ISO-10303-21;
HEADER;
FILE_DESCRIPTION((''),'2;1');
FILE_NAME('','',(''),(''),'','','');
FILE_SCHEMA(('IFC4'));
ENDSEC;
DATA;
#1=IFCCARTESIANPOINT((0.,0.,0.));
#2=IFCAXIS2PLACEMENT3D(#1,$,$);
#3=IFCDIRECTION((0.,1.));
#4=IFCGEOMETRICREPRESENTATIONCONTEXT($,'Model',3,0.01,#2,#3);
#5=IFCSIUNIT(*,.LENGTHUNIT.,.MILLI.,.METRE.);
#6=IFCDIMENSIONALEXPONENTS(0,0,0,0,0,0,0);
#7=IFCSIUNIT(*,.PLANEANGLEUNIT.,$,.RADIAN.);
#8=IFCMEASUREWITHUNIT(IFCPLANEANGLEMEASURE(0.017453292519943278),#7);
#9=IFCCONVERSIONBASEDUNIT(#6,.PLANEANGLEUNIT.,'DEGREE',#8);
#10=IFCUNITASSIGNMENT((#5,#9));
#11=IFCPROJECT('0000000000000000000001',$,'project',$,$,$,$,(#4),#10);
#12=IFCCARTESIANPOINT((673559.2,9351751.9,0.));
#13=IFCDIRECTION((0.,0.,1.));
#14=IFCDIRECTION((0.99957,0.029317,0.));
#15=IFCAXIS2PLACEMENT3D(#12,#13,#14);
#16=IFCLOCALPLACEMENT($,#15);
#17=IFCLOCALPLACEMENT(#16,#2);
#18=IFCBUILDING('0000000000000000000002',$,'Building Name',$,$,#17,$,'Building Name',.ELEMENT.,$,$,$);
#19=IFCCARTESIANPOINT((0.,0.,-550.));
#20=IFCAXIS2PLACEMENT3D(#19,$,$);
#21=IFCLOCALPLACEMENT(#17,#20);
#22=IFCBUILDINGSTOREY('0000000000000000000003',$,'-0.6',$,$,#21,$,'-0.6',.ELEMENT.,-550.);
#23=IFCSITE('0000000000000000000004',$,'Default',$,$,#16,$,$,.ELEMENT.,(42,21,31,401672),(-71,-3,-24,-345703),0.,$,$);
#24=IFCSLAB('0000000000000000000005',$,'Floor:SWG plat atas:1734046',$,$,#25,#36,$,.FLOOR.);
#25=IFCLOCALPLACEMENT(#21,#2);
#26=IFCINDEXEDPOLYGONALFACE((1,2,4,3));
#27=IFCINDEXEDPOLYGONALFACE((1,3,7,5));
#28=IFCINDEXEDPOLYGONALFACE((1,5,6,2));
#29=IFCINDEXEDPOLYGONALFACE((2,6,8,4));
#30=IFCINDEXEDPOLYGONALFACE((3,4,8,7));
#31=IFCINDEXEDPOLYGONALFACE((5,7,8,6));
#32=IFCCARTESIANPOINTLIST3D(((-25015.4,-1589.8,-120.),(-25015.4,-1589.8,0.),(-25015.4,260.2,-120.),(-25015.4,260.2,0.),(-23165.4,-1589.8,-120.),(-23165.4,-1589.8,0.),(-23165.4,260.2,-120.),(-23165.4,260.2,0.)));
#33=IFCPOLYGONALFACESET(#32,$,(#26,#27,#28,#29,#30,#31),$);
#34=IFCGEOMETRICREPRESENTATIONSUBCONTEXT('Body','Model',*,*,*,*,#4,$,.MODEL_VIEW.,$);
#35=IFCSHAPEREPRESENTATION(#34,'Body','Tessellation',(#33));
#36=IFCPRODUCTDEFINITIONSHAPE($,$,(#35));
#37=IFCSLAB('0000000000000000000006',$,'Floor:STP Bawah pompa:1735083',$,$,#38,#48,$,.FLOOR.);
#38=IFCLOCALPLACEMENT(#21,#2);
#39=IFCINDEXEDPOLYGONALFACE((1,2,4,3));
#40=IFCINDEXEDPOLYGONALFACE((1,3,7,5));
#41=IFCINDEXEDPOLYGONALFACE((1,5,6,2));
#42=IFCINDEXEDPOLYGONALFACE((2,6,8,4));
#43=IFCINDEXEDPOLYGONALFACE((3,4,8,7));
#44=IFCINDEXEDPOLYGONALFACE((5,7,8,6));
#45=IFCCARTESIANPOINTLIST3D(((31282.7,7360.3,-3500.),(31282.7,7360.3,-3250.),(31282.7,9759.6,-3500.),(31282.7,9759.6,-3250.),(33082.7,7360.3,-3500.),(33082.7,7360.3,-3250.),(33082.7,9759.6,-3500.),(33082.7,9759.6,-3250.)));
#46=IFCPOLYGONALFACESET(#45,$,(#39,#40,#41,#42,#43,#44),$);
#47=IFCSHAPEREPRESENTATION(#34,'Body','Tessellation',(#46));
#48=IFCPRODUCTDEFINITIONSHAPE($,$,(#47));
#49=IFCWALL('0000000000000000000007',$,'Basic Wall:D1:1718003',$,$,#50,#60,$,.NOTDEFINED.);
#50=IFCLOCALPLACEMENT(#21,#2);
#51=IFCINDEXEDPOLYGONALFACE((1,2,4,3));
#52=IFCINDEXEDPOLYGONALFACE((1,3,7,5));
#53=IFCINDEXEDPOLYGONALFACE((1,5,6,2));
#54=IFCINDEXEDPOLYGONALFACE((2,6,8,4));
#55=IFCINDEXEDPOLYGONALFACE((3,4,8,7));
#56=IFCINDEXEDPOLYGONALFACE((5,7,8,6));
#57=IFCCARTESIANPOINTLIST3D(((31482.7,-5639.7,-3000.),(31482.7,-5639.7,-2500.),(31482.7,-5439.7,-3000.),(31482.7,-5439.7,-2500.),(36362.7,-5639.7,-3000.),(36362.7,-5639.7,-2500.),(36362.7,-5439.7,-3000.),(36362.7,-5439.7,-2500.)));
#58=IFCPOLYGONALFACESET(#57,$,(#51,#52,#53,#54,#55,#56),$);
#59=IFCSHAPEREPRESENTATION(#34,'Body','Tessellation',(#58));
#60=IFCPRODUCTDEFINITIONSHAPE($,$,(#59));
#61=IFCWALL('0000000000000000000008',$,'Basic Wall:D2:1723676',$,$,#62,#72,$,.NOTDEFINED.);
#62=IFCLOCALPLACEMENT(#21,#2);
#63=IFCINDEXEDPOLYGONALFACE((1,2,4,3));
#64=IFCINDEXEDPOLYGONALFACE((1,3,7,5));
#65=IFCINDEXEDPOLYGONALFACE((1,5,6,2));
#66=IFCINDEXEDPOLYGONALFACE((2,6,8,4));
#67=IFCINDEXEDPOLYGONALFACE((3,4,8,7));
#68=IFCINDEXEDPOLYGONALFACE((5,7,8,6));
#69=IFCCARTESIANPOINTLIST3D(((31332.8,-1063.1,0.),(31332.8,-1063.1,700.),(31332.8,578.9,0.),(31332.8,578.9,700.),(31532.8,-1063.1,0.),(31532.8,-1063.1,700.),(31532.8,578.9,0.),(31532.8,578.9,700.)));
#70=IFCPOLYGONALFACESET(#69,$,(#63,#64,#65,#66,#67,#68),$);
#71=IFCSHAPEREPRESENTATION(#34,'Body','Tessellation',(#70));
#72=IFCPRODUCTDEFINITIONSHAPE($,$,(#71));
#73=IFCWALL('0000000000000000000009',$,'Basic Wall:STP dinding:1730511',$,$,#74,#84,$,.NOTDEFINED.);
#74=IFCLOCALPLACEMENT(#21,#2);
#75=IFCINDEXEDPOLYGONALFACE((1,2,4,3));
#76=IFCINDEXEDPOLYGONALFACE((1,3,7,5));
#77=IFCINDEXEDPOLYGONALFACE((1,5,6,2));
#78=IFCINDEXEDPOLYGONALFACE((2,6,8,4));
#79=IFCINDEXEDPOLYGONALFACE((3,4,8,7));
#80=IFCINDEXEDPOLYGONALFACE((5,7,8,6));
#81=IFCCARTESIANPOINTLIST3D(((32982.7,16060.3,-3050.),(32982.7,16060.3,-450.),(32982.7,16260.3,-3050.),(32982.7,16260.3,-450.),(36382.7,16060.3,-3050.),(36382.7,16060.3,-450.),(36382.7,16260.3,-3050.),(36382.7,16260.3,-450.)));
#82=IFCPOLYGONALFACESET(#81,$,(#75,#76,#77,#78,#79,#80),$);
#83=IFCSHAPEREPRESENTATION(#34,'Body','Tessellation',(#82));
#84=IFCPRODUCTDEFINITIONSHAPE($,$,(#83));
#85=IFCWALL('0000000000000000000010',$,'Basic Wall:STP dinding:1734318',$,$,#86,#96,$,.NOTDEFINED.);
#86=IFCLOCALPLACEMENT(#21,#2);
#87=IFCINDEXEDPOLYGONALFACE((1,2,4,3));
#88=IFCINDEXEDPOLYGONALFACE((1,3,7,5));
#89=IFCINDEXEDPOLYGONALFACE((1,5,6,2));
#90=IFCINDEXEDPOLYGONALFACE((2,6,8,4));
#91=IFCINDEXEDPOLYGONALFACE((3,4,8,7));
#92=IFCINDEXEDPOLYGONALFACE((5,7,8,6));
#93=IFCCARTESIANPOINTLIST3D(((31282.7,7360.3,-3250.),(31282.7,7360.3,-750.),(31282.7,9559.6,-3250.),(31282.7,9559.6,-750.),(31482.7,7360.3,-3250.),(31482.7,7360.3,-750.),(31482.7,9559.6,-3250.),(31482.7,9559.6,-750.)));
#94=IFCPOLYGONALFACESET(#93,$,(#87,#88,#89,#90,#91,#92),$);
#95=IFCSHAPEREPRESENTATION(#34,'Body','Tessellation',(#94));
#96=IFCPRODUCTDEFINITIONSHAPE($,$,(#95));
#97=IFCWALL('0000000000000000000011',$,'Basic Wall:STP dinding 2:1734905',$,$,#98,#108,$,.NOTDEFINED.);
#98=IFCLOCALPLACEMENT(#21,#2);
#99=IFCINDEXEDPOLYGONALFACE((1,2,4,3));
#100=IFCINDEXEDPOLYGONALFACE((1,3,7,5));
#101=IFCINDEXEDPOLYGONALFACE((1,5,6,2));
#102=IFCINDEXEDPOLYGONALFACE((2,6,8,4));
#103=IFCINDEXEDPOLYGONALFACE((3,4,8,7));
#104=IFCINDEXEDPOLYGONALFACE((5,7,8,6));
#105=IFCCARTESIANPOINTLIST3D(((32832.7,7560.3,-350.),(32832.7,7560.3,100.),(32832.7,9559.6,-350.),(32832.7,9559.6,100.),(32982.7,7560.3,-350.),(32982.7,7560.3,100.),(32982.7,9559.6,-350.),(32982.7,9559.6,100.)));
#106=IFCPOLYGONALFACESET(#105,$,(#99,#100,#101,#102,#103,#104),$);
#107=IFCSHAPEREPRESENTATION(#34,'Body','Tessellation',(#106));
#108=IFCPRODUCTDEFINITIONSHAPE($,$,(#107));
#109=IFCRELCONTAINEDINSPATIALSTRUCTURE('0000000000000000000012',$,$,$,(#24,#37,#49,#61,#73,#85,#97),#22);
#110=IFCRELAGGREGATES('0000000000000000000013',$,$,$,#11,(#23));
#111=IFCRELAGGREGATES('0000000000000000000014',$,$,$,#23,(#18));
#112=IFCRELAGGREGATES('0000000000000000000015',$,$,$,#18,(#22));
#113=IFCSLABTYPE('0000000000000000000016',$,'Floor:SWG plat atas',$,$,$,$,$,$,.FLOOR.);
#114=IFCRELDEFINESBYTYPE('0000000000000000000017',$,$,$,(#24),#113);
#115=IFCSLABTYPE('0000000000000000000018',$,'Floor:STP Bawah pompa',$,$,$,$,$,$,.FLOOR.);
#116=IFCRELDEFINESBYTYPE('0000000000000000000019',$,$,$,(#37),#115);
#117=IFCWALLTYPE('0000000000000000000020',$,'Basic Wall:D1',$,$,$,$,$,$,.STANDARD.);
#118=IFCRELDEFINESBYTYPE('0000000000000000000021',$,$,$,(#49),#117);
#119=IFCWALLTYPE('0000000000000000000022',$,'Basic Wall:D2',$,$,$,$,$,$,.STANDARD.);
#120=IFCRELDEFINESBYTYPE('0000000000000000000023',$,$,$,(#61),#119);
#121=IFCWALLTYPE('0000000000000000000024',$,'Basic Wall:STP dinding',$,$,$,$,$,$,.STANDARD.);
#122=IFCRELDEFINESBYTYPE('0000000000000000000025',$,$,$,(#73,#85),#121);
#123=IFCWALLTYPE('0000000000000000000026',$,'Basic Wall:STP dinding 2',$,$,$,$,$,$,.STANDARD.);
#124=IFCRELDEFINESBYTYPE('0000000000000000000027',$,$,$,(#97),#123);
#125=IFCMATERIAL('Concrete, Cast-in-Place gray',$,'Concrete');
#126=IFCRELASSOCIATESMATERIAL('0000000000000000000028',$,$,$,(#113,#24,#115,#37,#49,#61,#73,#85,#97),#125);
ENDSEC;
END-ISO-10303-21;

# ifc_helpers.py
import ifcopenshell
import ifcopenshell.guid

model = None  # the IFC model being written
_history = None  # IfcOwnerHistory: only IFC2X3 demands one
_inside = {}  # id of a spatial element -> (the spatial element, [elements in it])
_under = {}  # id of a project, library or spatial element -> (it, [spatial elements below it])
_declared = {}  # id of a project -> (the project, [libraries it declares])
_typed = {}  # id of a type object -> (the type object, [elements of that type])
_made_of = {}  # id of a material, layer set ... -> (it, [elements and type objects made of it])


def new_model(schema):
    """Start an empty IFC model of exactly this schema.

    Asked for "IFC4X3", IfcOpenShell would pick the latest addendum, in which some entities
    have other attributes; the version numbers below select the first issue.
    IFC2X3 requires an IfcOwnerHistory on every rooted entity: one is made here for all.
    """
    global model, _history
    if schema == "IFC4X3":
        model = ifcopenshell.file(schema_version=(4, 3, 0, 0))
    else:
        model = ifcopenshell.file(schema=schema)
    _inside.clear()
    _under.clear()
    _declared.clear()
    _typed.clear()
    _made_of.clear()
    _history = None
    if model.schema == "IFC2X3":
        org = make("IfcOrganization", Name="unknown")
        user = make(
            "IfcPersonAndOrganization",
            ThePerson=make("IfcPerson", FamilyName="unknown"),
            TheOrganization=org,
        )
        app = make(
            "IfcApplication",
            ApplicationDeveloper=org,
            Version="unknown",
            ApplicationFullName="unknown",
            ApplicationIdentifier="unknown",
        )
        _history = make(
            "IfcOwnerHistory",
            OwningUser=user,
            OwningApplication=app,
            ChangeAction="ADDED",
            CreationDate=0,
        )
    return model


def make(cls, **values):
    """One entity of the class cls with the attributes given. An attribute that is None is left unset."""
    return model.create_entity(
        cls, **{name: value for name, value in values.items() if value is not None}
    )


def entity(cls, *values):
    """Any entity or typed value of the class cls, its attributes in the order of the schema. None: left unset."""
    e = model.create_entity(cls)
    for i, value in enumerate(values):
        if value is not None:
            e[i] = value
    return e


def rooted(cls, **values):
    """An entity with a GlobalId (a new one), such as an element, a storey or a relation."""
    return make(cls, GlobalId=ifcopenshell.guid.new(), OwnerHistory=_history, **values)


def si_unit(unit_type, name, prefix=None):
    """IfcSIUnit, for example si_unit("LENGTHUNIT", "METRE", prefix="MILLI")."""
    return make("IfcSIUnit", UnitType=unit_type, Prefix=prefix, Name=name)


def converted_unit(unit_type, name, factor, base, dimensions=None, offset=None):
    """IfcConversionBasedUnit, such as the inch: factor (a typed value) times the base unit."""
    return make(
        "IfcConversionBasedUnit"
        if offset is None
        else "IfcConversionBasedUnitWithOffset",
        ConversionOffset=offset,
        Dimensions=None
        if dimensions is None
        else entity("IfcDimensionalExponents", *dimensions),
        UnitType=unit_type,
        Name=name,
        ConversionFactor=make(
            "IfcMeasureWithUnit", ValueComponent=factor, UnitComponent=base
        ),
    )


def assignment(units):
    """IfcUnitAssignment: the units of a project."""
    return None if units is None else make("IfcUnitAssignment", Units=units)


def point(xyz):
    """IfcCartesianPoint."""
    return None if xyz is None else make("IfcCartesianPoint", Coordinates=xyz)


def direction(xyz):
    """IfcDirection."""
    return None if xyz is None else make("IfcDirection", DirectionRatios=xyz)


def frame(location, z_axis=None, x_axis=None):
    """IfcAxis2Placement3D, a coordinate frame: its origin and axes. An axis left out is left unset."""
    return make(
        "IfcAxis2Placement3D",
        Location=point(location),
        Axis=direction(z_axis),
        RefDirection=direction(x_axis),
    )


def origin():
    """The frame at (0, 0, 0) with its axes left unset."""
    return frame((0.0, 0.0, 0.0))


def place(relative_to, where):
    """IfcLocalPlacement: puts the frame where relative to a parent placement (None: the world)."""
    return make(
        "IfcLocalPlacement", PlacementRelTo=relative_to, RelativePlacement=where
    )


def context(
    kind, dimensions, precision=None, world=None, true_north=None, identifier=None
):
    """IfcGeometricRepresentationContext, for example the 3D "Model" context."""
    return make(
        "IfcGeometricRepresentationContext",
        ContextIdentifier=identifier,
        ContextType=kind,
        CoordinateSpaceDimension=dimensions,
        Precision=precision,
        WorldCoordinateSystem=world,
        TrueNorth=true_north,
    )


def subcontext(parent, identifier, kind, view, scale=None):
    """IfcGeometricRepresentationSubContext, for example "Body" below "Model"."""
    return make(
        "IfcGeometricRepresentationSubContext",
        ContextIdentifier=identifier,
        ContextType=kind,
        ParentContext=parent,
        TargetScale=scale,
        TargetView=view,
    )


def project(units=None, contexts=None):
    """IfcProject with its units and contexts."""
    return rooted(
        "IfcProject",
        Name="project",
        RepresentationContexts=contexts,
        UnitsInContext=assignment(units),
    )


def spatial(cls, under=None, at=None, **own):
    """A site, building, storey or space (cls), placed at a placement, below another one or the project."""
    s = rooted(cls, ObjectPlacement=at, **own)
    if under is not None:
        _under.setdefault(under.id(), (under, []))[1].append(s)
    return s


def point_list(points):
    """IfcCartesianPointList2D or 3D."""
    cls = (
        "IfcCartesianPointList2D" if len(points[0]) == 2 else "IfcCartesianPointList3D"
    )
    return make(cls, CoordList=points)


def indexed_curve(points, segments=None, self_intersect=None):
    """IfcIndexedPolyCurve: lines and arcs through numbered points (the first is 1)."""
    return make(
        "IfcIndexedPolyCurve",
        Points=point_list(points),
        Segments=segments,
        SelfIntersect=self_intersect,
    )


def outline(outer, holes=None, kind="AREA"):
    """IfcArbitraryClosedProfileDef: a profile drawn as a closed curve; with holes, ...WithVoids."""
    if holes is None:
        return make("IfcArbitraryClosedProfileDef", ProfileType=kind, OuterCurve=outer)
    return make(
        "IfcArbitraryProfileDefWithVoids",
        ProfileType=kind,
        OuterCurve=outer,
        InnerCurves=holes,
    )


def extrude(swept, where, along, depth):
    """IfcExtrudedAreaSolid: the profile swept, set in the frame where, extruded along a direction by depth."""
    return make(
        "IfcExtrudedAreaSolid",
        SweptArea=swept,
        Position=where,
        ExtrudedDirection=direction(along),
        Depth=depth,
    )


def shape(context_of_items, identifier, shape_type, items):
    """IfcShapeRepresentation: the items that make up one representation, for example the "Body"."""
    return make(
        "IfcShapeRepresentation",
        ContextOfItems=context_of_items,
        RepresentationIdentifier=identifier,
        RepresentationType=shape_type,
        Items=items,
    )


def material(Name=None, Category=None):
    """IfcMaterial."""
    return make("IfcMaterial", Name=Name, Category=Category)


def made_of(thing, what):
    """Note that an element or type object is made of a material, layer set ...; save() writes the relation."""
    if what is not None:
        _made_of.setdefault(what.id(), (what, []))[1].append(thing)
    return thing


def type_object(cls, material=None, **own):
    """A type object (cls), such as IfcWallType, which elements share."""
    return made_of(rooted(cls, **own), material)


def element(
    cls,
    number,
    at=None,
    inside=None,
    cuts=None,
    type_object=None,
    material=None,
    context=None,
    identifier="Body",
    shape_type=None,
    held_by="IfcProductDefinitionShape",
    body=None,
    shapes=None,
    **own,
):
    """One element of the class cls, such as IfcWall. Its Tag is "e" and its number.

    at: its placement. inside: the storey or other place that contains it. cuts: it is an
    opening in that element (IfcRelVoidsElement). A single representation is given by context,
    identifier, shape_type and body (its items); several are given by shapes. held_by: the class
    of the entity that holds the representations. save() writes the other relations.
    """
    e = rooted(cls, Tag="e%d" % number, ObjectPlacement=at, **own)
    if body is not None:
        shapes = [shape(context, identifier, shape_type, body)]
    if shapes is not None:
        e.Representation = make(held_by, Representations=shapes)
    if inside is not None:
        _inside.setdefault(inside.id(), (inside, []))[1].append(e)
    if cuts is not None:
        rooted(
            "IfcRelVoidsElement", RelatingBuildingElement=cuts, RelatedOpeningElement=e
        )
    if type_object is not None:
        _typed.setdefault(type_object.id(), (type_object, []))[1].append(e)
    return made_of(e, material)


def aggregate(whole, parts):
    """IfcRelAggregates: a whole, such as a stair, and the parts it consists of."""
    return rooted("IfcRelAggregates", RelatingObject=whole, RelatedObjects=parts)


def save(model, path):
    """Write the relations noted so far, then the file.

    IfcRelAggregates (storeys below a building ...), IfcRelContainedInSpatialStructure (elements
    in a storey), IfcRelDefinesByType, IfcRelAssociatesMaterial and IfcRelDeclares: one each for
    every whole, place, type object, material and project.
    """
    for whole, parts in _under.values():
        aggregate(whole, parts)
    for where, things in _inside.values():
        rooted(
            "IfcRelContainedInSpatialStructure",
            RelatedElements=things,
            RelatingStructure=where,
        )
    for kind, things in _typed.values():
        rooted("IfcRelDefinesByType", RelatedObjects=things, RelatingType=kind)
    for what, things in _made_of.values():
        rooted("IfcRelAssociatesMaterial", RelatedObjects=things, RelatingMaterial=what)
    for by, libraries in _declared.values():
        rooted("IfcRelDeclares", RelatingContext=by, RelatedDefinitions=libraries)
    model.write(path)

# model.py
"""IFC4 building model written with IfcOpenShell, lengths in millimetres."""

from ifc_helpers import new_model, entity, si_unit, converted_unit, direction, frame, origin, place, context, subcontext, project, spatial, indexed_curve, outline, extrude, material, type_object, element, save


model = new_model("IFC4")

# Units and contexts
model_context = context("Model", 3, precision=0.01, world=origin(), true_north=direction((0.0, 1.0)))
body_context = subcontext(model_context, "Body", "Model", "MODEL_VIEW")
ifc_project = project(units=[si_unit("LENGTHUNIT", "METRE", prefix="MILLI"), converted_unit("PLANEANGLEUNIT", "DEGREE", entity("IfcPlaneAngleMeasure", 0.017453292519943278), si_unit("PLANEANGLEUNIT", "RADIAN"), dimensions=[0, 0, 0, 0, 0, 0, 0])], contexts=[model_context])

# Site, building, storey
site_placement = place(None, frame((673559.2, 9351751.9, 0.0), z_axis=(0.0, 0.0, 1.0), x_axis=(0.99957, 0.029317, 0.0)))
site = spatial("IfcSite", under=ifc_project, at=site_placement, Name="Default", CompositionType="ELEMENT", RefLatitude=(42, 21, 31, 401672), RefLongitude=(-71, -3, -24, -345703), RefElevation=0.0)
building_placement = place(site_placement, origin())
building = spatial("IfcBuilding", under=site, at=building_placement, Name="Building Name", LongName="Building Name", CompositionType="ELEMENT")
storey_placement = place(building_placement, frame((0.0, 0.0, -550.0)))
storey = spatial("IfcBuildingStorey", under=building, at=storey_placement, Name="-0.6", LongName="-0.6", CompositionType="ELEMENT", Elevation=-550.0)

# Slabs
ifc_material_1 = material(Name="Concrete, Cast-in-Place gray", Category="Concrete")
slab_type_1 = type_object("IfcSlabType", Name="Floor:SWG plat atas", PredefinedType="FLOOR", material=ifc_material_1)
slab_1_placement = place(storey_placement, origin())
element("IfcSlab", 1, at=slab_1_placement, inside=storey, type_object=slab_type_1, material=ifc_material_1, Name="Floor:SWG plat atas:1734046", PredefinedType="FLOOR", context=body_context, shape_type="SweptSolid", body=[
    extrude(outline(indexed_curve([(-925.0, -925.0), (925.0, -925.0), (925.0, 925.0), (-925.0, 925.0), (-925.0, -925.0)], self_intersect=False)), frame((-24090.4, -664.8, 0.0), z_axis=(0.0, 0.0, -1.0), x_axis=(0.0, 1.0, 0.0)), (0.0, 0.0, 1.0), 120.0),
])
slab_type_2 = type_object("IfcSlabType", Name="Floor:STP Bawah pompa", PredefinedType="FLOOR", material=ifc_material_1)
slab_2_placement = place(storey_placement, origin())
element("IfcSlab", 2, at=slab_2_placement, inside=storey, type_object=slab_type_2, material=ifc_material_1, Name="Floor:STP Bawah pompa:1735083", PredefinedType="FLOOR", context=body_context, shape_type="SweptSolid", body=[
    extrude(outline(indexed_curve([(-1199.7, -900.0), (1199.7, -900.0), (1199.7, 900.0), (-1199.7, 900.0), (-1199.7, -900.0)], self_intersect=False)), frame((32182.7, 8560.0, -3250.0), z_axis=(0.0, 0.0, -1.0), x_axis=(0.0, 1.0, 0.0)), (0.0, 0.0, 1.0), 250.0),
])

# Walls
wall_type_1 = type_object("IfcWallType", Name="Basic Wall:D1", PredefinedType="STANDARD")
wall_1_placement = place(storey_placement, frame((31482.7, -5539.7, -3000.0)))
element("IfcWall", 3, at=wall_1_placement, inside=storey, type_object=wall_type_1, material=ifc_material_1, Name="Basic Wall:D1:1718003", PredefinedType="NOTDEFINED", context=body_context, shape_type="SweptSolid", body=[
    extrude(outline(indexed_curve([(4880.0, 100.0), (0.0, 100.0), (0.0, -100.0), (4880.0, -100.0), (4880.0, 100.0)], self_intersect=False)), origin(), (0.0, 0.0, 1.0), 500.0),
])
wall_type_2 = type_object("IfcWallType", Name="Basic Wall:D2", PredefinedType="STANDARD")
wall_2_placement = place(storey_placement, frame((31432.8, 578.9, 0.0), z_axis=(0.0, 0.0, 1.0), x_axis=(0.0, -1.0, 0.0)))
element("IfcWall", 4, at=wall_2_placement, inside=storey, type_object=wall_type_2, material=ifc_material_1, Name="Basic Wall:D2:1723676", PredefinedType="NOTDEFINED", context=body_context, shape_type="SweptSolid", body=[
    extrude(outline(indexed_curve([(1642.0, 100.0), (0.0, 100.0), (0.0, -100.0), (1642.0, -100.0), (1642.0, 100.0)], self_intersect=False)), origin(), (0.0, 0.0, 1.0), 700.0),
])
wall_type_3 = type_object("IfcWallType", Name="Basic Wall:STP dinding", PredefinedType="STANDARD")
wall_3_placement = place(storey_placement, frame((32982.7, 16160.3, -3050.0)))
element("IfcWall", 5, at=wall_3_placement, inside=storey, type_object=wall_type_3, material=ifc_material_1, Name="Basic Wall:STP dinding:1730511", PredefinedType="NOTDEFINED", context=body_context, shape_type="SweptSolid", body=[
    extrude(outline(indexed_curve([(3400.0, 100.0), (0.0, 100.0), (0.0, -100.0), (3400.0, -100.0), (3400.0, 100.0)], self_intersect=False)), origin(), (0.0, 0.0, 1.0), 2600.0),
])
wall_4_placement = place(storey_placement, frame((31382.7, 9559.6, -3250.0), z_axis=(0.0, 0.0, 1.0), x_axis=(0.0, -1.0, 0.0)))
element("IfcWall", 6, at=wall_4_placement, inside=storey, type_object=wall_type_3, material=ifc_material_1, Name="Basic Wall:STP dinding:1734318", PredefinedType="NOTDEFINED", context=body_context, shape_type="SweptSolid", body=[
    extrude(outline(indexed_curve([(2199.3, 100.0), (0.0, 100.0), (0.0, -100.0), (2199.3, -100.0), (2199.3, 100.0)], self_intersect=False)), origin(), (0.0, 0.0, 1.0), 2500.0),
])
wall_type_4 = type_object("IfcWallType", Name="Basic Wall:STP dinding 2", PredefinedType="STANDARD")
wall_5_placement = place(storey_placement, frame((32907.7, 9559.6, -350.0), z_axis=(0.0, 0.0, 1.0), x_axis=(0.0, -1.0, 0.0)))
element("IfcWall", 7, at=wall_5_placement, inside=storey, type_object=wall_type_4, material=ifc_material_1, Name="Basic Wall:STP dinding 2:1734905", PredefinedType="NOTDEFINED", context=body_context, shape_type="SweptSolid", body=[
    extrude(outline(indexed_curve([(1999.3, 75.0), (0.0, 75.0), (0.0, -75.0), (1999.3, -75.0), (1999.3, 75.0)], self_intersect=False)), origin(), (0.0, 0.0, 1.0), 450.0),
])

save(model, "model.ifc")
